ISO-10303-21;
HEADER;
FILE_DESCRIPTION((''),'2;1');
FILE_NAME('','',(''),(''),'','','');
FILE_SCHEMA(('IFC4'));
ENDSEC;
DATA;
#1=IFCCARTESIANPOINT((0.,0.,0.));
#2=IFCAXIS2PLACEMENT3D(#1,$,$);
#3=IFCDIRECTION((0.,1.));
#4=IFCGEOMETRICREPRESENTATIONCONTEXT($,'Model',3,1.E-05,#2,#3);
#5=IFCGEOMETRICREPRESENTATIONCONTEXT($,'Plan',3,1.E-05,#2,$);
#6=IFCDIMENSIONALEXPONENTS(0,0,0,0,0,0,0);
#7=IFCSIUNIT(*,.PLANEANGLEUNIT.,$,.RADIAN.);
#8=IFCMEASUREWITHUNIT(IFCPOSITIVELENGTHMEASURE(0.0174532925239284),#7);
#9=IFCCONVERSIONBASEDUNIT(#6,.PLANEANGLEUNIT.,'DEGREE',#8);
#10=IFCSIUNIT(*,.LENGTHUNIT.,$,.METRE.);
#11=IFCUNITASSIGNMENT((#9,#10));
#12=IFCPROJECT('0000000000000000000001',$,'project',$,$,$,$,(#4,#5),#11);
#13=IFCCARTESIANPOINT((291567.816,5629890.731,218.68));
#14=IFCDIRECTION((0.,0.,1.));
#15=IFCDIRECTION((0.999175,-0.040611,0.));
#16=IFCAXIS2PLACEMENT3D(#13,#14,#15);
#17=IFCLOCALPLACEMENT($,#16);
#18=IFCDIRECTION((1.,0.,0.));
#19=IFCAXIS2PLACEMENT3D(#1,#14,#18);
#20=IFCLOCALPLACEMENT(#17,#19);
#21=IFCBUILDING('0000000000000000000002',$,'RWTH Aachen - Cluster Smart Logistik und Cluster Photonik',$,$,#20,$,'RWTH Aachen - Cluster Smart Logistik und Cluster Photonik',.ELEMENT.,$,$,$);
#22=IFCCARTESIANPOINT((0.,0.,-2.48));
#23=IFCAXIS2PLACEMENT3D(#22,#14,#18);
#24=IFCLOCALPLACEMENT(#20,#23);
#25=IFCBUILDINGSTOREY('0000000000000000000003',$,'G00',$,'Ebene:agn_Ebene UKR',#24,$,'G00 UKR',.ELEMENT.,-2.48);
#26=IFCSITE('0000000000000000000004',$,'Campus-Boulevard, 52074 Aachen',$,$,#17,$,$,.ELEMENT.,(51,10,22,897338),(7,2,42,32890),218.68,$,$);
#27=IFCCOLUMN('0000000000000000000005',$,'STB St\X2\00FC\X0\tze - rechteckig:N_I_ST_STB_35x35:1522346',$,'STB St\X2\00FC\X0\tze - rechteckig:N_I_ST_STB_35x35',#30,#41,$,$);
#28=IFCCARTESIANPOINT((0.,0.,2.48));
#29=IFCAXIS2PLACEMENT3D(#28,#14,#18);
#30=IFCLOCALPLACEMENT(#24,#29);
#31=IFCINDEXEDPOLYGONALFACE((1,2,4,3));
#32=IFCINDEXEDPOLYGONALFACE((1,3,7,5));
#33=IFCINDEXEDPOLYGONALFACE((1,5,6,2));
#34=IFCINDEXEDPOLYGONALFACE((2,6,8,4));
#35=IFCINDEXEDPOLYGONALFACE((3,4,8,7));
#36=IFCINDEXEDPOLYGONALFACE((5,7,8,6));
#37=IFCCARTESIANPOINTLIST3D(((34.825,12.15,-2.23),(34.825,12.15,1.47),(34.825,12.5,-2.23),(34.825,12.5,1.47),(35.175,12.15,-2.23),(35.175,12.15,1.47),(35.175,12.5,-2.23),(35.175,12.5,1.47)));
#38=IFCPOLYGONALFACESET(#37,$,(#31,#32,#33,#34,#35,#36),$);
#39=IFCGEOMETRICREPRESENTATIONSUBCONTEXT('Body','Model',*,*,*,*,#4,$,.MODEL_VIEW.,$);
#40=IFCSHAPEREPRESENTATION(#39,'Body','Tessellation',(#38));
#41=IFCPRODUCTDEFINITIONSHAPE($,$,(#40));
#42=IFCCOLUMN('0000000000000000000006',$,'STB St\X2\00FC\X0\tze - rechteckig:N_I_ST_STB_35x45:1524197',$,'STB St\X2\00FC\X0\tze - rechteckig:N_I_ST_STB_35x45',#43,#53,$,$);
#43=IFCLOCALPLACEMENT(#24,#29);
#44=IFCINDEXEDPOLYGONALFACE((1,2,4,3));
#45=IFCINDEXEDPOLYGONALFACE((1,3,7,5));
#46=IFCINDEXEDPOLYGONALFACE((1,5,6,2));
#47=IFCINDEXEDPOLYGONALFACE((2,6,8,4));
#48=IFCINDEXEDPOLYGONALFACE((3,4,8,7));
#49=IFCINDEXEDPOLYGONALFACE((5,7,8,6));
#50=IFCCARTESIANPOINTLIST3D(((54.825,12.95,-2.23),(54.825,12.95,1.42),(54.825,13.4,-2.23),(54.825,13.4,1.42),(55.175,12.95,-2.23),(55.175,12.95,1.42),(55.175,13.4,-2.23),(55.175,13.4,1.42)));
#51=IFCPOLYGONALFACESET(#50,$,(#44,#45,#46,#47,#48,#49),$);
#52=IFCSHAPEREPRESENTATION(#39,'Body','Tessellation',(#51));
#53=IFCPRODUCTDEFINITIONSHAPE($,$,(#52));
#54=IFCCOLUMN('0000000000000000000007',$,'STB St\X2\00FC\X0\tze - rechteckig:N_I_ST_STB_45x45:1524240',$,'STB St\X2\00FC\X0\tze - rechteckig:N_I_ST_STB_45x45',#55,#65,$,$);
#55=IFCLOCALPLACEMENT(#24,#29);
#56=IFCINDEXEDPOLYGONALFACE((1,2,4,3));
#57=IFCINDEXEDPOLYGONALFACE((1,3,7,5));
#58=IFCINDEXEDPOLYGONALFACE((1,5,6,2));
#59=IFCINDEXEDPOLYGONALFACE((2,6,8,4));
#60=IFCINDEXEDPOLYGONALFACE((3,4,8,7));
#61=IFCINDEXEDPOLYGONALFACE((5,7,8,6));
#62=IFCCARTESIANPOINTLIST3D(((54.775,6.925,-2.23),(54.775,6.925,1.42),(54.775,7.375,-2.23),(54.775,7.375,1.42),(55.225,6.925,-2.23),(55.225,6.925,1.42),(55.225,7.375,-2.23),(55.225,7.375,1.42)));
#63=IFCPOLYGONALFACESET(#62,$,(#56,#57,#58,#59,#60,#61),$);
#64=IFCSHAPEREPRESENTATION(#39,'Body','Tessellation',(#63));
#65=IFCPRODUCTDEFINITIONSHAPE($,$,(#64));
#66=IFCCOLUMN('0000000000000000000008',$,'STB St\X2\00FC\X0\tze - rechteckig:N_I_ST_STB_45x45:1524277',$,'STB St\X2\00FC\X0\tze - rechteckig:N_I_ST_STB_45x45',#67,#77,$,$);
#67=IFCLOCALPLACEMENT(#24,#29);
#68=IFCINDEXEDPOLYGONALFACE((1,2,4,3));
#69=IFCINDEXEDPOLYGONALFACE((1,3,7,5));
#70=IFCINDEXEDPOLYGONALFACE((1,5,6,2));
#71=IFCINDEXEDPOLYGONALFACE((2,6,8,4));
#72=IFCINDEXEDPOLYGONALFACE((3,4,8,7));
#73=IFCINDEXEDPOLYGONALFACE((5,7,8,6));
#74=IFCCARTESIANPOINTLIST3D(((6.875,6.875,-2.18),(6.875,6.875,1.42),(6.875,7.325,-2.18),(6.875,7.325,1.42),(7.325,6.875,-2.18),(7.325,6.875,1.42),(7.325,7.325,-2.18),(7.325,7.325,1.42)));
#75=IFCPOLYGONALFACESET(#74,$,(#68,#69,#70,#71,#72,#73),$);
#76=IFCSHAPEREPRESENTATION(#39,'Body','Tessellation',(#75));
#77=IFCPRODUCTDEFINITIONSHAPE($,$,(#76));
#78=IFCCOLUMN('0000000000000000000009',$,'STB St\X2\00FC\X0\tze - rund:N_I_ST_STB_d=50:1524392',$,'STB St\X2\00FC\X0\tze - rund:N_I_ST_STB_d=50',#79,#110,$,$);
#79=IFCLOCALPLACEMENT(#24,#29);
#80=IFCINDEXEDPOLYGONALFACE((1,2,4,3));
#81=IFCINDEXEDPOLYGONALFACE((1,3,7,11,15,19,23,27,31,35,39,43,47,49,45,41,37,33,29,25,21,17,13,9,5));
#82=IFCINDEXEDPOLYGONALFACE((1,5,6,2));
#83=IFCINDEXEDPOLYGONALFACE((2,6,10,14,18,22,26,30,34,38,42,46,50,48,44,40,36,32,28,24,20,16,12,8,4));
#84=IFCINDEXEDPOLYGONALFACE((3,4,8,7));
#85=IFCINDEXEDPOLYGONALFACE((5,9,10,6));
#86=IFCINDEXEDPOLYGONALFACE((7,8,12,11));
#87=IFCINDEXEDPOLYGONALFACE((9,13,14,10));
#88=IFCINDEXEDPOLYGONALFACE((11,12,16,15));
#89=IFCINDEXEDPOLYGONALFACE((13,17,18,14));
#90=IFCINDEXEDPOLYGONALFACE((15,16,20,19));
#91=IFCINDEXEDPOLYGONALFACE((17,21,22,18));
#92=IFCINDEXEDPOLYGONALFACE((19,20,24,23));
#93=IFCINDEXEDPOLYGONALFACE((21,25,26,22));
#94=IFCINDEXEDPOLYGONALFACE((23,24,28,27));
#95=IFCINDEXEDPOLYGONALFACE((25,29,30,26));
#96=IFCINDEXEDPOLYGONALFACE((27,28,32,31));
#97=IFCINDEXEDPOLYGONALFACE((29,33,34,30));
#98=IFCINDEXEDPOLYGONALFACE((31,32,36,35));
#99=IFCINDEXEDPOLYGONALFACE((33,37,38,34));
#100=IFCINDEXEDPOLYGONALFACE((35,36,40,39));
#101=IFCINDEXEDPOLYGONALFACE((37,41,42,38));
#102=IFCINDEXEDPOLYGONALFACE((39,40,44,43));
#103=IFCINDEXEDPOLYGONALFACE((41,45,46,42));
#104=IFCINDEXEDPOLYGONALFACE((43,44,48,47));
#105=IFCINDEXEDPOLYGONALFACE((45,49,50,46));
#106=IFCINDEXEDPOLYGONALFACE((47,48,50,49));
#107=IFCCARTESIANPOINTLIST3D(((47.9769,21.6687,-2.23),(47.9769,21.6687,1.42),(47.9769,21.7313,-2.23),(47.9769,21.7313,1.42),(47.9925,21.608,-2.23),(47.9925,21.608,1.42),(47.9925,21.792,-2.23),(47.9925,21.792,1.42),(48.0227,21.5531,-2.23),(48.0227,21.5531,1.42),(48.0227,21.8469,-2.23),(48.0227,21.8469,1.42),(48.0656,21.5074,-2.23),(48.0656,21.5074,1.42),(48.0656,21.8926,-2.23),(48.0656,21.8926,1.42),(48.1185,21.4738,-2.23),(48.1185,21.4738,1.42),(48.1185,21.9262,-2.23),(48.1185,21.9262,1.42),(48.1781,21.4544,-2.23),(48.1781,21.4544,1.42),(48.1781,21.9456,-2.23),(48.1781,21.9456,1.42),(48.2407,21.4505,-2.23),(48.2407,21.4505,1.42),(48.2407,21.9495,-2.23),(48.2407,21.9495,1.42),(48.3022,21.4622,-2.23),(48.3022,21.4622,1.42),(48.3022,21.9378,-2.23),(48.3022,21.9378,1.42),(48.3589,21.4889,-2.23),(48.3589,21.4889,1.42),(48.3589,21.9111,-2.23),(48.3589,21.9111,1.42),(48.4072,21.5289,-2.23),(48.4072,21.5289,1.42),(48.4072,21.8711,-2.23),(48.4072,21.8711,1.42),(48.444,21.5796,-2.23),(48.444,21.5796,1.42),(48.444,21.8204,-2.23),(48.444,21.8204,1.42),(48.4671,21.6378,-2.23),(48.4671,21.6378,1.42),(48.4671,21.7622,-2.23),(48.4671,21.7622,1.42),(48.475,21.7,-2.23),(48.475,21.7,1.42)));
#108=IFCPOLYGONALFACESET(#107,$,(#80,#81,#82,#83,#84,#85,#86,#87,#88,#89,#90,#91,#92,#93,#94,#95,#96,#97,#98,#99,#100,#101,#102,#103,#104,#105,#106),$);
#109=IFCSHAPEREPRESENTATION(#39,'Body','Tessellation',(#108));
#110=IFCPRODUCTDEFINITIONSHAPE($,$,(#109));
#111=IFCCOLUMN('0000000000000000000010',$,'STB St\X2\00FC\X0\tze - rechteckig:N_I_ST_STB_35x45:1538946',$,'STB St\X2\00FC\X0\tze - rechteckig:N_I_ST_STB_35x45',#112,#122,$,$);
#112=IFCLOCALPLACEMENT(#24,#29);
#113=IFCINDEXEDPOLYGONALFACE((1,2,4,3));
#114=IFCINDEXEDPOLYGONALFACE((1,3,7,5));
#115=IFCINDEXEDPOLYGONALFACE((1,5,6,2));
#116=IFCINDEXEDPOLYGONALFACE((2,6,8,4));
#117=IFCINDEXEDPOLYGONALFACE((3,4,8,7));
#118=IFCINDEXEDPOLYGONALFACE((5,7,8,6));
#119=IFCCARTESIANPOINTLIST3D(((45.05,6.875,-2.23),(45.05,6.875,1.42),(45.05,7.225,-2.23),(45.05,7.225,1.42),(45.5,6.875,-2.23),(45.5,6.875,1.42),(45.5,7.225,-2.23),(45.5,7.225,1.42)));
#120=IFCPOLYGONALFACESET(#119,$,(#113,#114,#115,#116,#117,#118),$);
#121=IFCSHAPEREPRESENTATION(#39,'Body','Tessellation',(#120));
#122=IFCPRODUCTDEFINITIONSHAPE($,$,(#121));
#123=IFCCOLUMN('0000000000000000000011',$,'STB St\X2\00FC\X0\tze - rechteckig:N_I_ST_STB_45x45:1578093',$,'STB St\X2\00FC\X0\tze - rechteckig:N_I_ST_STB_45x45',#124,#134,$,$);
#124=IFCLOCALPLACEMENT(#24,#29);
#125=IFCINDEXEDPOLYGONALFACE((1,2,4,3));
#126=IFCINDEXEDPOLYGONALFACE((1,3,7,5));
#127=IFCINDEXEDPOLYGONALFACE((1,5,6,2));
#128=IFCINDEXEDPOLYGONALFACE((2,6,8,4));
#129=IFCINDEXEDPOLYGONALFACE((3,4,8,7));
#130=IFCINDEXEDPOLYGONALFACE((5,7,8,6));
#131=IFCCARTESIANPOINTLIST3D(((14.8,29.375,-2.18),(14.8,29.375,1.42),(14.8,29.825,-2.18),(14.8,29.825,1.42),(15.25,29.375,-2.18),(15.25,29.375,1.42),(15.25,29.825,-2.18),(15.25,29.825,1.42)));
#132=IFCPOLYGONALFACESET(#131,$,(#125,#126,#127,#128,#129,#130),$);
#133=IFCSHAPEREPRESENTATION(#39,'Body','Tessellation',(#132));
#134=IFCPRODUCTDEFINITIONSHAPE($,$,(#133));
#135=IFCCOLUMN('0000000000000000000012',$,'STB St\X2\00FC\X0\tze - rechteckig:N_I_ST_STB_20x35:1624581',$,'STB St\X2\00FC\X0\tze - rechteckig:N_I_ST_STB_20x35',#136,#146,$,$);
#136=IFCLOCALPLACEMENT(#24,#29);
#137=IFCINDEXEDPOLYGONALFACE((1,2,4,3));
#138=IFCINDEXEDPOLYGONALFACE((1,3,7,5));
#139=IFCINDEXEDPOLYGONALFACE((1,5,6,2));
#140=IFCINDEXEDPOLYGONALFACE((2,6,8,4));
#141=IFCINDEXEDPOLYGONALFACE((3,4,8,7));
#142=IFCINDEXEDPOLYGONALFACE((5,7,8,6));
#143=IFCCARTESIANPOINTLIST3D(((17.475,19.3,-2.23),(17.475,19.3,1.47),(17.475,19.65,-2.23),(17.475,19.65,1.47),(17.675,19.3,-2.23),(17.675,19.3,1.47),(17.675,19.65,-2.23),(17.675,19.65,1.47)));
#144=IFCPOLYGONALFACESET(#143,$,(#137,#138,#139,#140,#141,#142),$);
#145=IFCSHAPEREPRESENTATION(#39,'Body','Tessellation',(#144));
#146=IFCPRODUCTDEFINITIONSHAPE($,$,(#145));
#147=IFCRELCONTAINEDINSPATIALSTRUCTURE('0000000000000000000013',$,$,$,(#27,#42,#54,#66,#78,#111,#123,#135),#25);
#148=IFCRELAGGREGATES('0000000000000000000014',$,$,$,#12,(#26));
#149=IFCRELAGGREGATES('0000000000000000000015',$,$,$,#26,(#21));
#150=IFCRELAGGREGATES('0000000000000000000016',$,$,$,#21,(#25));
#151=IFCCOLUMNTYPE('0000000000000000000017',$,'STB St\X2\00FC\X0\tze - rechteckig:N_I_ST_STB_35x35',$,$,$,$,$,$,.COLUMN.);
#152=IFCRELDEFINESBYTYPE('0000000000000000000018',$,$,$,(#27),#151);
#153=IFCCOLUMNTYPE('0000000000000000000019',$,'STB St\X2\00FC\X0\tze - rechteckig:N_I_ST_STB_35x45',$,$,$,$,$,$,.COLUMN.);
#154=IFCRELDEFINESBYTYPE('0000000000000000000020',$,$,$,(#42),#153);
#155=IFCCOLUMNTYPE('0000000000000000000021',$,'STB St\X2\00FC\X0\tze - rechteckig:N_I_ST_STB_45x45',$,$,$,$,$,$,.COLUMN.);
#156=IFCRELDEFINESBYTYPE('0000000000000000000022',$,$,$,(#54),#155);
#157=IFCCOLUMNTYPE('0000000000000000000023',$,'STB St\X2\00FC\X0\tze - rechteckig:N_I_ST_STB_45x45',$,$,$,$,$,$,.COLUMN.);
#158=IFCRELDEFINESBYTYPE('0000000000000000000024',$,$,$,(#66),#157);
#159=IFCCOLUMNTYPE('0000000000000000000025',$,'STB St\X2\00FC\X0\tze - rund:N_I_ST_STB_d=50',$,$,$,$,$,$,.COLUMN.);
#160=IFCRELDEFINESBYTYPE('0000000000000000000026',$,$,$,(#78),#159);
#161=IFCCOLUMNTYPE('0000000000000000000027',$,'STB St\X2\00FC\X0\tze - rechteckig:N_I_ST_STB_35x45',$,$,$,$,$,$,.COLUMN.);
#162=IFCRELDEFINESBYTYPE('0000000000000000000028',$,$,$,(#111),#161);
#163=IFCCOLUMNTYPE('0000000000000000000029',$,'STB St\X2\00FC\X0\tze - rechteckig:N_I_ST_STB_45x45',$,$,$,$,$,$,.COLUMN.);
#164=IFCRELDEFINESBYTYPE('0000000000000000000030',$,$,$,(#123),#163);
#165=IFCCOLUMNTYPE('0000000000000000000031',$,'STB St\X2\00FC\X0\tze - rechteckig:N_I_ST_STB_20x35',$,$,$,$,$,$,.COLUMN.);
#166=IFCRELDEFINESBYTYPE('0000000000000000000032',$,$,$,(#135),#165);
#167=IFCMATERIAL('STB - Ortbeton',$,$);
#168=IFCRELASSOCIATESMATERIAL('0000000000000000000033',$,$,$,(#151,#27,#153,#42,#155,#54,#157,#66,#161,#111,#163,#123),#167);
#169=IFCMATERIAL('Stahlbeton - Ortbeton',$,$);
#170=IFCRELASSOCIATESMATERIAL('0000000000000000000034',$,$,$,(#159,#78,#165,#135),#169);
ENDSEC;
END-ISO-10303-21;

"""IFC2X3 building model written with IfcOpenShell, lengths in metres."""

from ifc_helpers import new_model, entity, si_unit, converted_unit, direction, frame, frame_2d, origin, origin_with_axes, origin_2d_with_axis, place, context, subcontext, project, spatial, rectangle, circle, extrude, source, transform, mapped, material, type_object, element, save


model = new_model("IFC2X3")

# Units and contexts
model_context = context("Model", 3, precision=1e-05, world=origin(), true_north=direction((0.0, 1.0)))
plan_context = context("Plan", 3, precision=1e-05, world=origin())
body_context = subcontext(model_context, "Body", "Model", "MODEL_VIEW")
ifc_project = project(units=[converted_unit("PLANEANGLEUNIT", "DEGREE", entity("IfcPositiveLengthMeasure", 0.0174532925239284), si_unit("PLANEANGLEUNIT", "RADIAN"), dimensions=[0, 0, 0, 0, 0, 0, 0]), si_unit("LENGTHUNIT", "METRE")], contexts=[model_context, plan_context])

# Site, building, storey
site_placement = place(None, frame((291567.816, 5629890.731, 218.68), z_axis=(0.0, 0.0, 1.0), x_axis=(0.999175, -0.040611, 0.0)))
site = spatial("IfcSite", under=ifc_project, at=site_placement, Name="Campus-Boulevard, 52074 Aachen", CompositionType="ELEMENT", RefLatitude=(51, 10, 22, 897338), RefLongitude=(7, 2, 42, 32890), RefElevation=218.68)
building_placement = place(site_placement, origin_with_axes())
building = spatial("IfcBuilding", under=site, at=building_placement, Name="RWTH Aachen - Cluster Smart Logistik und Cluster Photonik", LongName="RWTH Aachen - Cluster Smart Logistik und Cluster Photonik", CompositionType="ELEMENT")
storey_placement = place(building_placement, frame((0.0, 0.0, -2.48), z_axis=(0.0, 0.0, 1.0), x_axis=(1.0, 0.0, 0.0)))
storey = spatial("IfcBuildingStorey", under=building, at=storey_placement, Name="G00", ObjectType="Ebene:agn_Ebene UKR", LongName="G00 UKR", CompositionType="ELEMENT", Elevation=-2.48)

# Shared definitions
ifc_material_1 = material(Name="STB - Ortbeton")

# Columns
column_type_1 = type_object("IfcColumnType", Name="STB Stütze - rechteckig:N_I_ST_STB_35x35", PredefinedType="COLUMN", material=ifc_material_1)
shared_shape_1 = source(origin(), body_context, "Body", "SweptSolid", [
    extrude(rectangle(XDim=0.35, YDim=0.35, at=origin_2d_with_axis()), frame((35.0, 12.325, -2.23), z_axis=(0.0, 0.0, 1.0), x_axis=(0.0, -1.0, 0.0)), (0.0, 0.0, 1.0), 3.7),
])
column_1_placement = place(storey_placement, frame((0.0, 0.0, 2.48), z_axis=(0.0, 0.0, 1.0), x_axis=(1.0, 0.0, 0.0)))
element("IfcColumn", 1, at=column_1_placement, inside=storey, type_object=column_type_1, material=ifc_material_1, Name="STB Stütze - rechteckig:N_I_ST_STB_35x35:1522346", ObjectType="STB Stütze - rechteckig:N_I_ST_STB_35x35", context=body_context, shape_type="MappedRepresentation", body=[
    mapped(shared_shape_1, transform((0.0, 0.0, 0.0), scale=1.0)),
])
column_type_2 = type_object("IfcColumnType", Name="STB Stütze - rechteckig:N_I_ST_STB_35x45", PredefinedType="COLUMN", material=ifc_material_1)
shared_shape_2 = source(origin(), body_context, "Body", "SweptSolid", [
    extrude(rectangle(XDim=0.45, YDim=0.35, at=origin_2d_with_axis()), frame((55.0, 13.175, -2.23), z_axis=(0.0, 0.0, 1.0), x_axis=(0.0, -1.0, 0.0)), (0.0, 0.0, 1.0), 3.65),
])
column_2_placement = place(storey_placement, frame((0.0, 0.0, 2.48), z_axis=(0.0, 0.0, 1.0), x_axis=(1.0, 0.0, 0.0)))
element("IfcColumn", 2, at=column_2_placement, inside=storey, type_object=column_type_2, material=ifc_material_1, Name="STB Stütze - rechteckig:N_I_ST_STB_35x45:1524197", ObjectType="STB Stütze - rechteckig:N_I_ST_STB_35x45", context=body_context, shape_type="MappedRepresentation", body=[
    mapped(shared_shape_2, transform((0.0, 0.0, 0.0), scale=1.0)),
])
column_type_3 = type_object("IfcColumnType", Name="STB Stütze - rechteckig:N_I_ST_STB_45x45", PredefinedType="COLUMN", material=ifc_material_1)
shared_shape_3 = source(origin(), body_context, "Body", "SweptSolid", [
    extrude(rectangle(XDim=0.45, YDim=0.45, at=frame_2d((0.0, 0.0), x_axis=(1.0, 0.0))), frame((55.0, 7.15, -2.23), z_axis=(0.0, 0.0, 1.0), x_axis=(0.0, -1.0, 0.0)), (0.0, 0.0, 1.0), 3.65),
])
column_3_placement = place(storey_placement, frame((0.0, 0.0, 2.48), z_axis=(0.0, 0.0, 1.0), x_axis=(1.0, 0.0, 0.0)))
element("IfcColumn", 3, at=column_3_placement, inside=storey, type_object=column_type_3, material=ifc_material_1, Name="STB Stütze - rechteckig:N_I_ST_STB_45x45:1524240", ObjectType="STB Stütze - rechteckig:N_I_ST_STB_45x45", context=body_context, shape_type="MappedRepresentation", body=[
    mapped(shared_shape_3, transform((0.0, 0.0, 0.0), scale=1.0)),
])
column_type_4 = type_object("IfcColumnType", Name="STB Stütze - rechteckig:N_I_ST_STB_45x45", PredefinedType="COLUMN", material=ifc_material_1)
shared_shape_4 = source(origin(), body_context, "Body", "SweptSolid", [
    extrude(rectangle(XDim=0.45, YDim=0.45, at=frame_2d((0.0, 0.0), x_axis=(1.0, 0.0))), frame((7.1, 7.1, -2.18), z_axis=(0.0, 0.0, 1.0), x_axis=(0.0, -1.0, 0.0)), (0.0, 0.0, 1.0), 3.6),
])
column_4_placement = place(storey_placement, frame((0.0, 0.0, 2.48), z_axis=(0.0, 0.0, 1.0), x_axis=(1.0, 0.0, 0.0)))
element("IfcColumn", 4, at=column_4_placement, inside=storey, type_object=column_type_4, material=ifc_material_1, Name="STB Stütze - rechteckig:N_I_ST_STB_45x45:1524277", ObjectType="STB Stütze - rechteckig:N_I_ST_STB_45x45", context=body_context, shape_type="MappedRepresentation", body=[
    mapped(shared_shape_4, transform((0.0, 0.0, 0.0), scale=1.0)),
])
ifc_material_2 = material(Name="Stahlbeton - Ortbeton")
column_type_5 = type_object("IfcColumnType", Name="STB Stütze - rund:N_I_ST_STB_d=50", PredefinedType="COLUMN", material=ifc_material_2)
shared_shape_5 = source(origin(), body_context, "Body", "SweptSolid", [
    extrude(circle(Radius=0.25, at=origin_2d_with_axis()), frame((48.225, 21.7, -2.23)), (0.0, 0.0, 1.0), 3.65),
])
column_5_placement = place(storey_placement, frame((0.0, 0.0, 2.48), z_axis=(0.0, 0.0, 1.0), x_axis=(1.0, 0.0, 0.0)))
element("IfcColumn", 5, at=column_5_placement, inside=storey, type_object=column_type_5, material=ifc_material_2, Name="STB Stütze - rund:N_I_ST_STB_d=50:1524392", ObjectType="STB Stütze - rund:N_I_ST_STB_d=50", context=body_context, shape_type="MappedRepresentation", body=[
    mapped(shared_shape_5, transform((0.0, 0.0, 0.0), scale=1.0)),
])
column_type_6 = type_object("IfcColumnType", Name="STB Stütze - rechteckig:N_I_ST_STB_35x45", PredefinedType="COLUMN", material=ifc_material_1)
shared_shape_6 = source(origin(), body_context, "Body", "SweptSolid", [
    extrude(rectangle(XDim=0.35, YDim=0.45, at=origin_2d_with_axis()), frame((45.275, 7.05, -2.23), z_axis=(0.0, 0.0, 1.0), x_axis=(0.0, -1.0, 0.0)), (0.0, 0.0, 1.0), 3.65),
])
column_6_placement = place(storey_placement, frame((0.0, 0.0, 2.48), z_axis=(0.0, 0.0, 1.0), x_axis=(1.0, 0.0, 0.0)))
element("IfcColumn", 6, at=column_6_placement, inside=storey, type_object=column_type_6, material=ifc_material_1, Name="STB Stütze - rechteckig:N_I_ST_STB_35x45:1538946", ObjectType="STB Stütze - rechteckig:N_I_ST_STB_35x45", context=body_context, shape_type="MappedRepresentation", body=[
    mapped(shared_shape_6, transform((0.0, 0.0, 0.0), scale=1.0)),
])
column_type_7 = type_object("IfcColumnType", Name="STB Stütze - rechteckig:N_I_ST_STB_45x45", PredefinedType="COLUMN", material=ifc_material_1)
shared_shape_7 = source(origin(), body_context, "Body", "SweptSolid", [
    extrude(rectangle(XDim=0.45, YDim=0.45, at=origin_2d_with_axis()), frame((15.025, 29.6, -2.18), z_axis=(0.0, 0.0, 1.0), x_axis=(0.0, -1.0, 0.0)), (0.0, 0.0, 1.0), 3.6),
])
column_7_placement = place(storey_placement, frame((0.0, 0.0, 2.48), z_axis=(0.0, 0.0, 1.0), x_axis=(1.0, 0.0, 0.0)))
element("IfcColumn", 7, at=column_7_placement, inside=storey, type_object=column_type_7, material=ifc_material_1, Name="STB Stütze - rechteckig:N_I_ST_STB_45x45:1578093", ObjectType="STB Stütze - rechteckig:N_I_ST_STB_45x45", context=body_context, shape_type="MappedRepresentation", body=[
    mapped(shared_shape_7, transform((0.0, 0.0, 0.0), scale=1.0)),
])
column_type_8 = type_object("IfcColumnType", Name="STB Stütze - rechteckig:N_I_ST_STB_20x35", PredefinedType="COLUMN", material=ifc_material_2)
shared_shape_8 = source(origin(), body_context, "Body", "SweptSolid", [
    extrude(rectangle(XDim=0.35, YDim=0.2, at=frame_2d((0.0, 0.0), x_axis=(1.0, 0.0))), frame((17.575, 19.475, -2.23), z_axis=(0.0, 0.0, 1.0), x_axis=(0.0, -1.0, 0.0)), (0.0, 0.0, 1.0), 3.7),
])
column_8_placement = place(storey_placement, frame((0.0, 0.0, 2.48), z_axis=(0.0, 0.0, 1.0), x_axis=(1.0, 0.0, 0.0)))
element("IfcColumn", 8, at=column_8_placement, inside=storey, type_object=column_type_8, material=ifc_material_2, Name="STB Stütze - rechteckig:N_I_ST_STB_20x35:1624581", ObjectType="STB Stütze - rechteckig:N_I_ST_STB_20x35", context=body_context, shape_type="MappedRepresentation", body=[
    mapped(shared_shape_8, transform((0.0, 0.0, 0.0), scale=1.0)),
])

save(model, "model.ifc")
